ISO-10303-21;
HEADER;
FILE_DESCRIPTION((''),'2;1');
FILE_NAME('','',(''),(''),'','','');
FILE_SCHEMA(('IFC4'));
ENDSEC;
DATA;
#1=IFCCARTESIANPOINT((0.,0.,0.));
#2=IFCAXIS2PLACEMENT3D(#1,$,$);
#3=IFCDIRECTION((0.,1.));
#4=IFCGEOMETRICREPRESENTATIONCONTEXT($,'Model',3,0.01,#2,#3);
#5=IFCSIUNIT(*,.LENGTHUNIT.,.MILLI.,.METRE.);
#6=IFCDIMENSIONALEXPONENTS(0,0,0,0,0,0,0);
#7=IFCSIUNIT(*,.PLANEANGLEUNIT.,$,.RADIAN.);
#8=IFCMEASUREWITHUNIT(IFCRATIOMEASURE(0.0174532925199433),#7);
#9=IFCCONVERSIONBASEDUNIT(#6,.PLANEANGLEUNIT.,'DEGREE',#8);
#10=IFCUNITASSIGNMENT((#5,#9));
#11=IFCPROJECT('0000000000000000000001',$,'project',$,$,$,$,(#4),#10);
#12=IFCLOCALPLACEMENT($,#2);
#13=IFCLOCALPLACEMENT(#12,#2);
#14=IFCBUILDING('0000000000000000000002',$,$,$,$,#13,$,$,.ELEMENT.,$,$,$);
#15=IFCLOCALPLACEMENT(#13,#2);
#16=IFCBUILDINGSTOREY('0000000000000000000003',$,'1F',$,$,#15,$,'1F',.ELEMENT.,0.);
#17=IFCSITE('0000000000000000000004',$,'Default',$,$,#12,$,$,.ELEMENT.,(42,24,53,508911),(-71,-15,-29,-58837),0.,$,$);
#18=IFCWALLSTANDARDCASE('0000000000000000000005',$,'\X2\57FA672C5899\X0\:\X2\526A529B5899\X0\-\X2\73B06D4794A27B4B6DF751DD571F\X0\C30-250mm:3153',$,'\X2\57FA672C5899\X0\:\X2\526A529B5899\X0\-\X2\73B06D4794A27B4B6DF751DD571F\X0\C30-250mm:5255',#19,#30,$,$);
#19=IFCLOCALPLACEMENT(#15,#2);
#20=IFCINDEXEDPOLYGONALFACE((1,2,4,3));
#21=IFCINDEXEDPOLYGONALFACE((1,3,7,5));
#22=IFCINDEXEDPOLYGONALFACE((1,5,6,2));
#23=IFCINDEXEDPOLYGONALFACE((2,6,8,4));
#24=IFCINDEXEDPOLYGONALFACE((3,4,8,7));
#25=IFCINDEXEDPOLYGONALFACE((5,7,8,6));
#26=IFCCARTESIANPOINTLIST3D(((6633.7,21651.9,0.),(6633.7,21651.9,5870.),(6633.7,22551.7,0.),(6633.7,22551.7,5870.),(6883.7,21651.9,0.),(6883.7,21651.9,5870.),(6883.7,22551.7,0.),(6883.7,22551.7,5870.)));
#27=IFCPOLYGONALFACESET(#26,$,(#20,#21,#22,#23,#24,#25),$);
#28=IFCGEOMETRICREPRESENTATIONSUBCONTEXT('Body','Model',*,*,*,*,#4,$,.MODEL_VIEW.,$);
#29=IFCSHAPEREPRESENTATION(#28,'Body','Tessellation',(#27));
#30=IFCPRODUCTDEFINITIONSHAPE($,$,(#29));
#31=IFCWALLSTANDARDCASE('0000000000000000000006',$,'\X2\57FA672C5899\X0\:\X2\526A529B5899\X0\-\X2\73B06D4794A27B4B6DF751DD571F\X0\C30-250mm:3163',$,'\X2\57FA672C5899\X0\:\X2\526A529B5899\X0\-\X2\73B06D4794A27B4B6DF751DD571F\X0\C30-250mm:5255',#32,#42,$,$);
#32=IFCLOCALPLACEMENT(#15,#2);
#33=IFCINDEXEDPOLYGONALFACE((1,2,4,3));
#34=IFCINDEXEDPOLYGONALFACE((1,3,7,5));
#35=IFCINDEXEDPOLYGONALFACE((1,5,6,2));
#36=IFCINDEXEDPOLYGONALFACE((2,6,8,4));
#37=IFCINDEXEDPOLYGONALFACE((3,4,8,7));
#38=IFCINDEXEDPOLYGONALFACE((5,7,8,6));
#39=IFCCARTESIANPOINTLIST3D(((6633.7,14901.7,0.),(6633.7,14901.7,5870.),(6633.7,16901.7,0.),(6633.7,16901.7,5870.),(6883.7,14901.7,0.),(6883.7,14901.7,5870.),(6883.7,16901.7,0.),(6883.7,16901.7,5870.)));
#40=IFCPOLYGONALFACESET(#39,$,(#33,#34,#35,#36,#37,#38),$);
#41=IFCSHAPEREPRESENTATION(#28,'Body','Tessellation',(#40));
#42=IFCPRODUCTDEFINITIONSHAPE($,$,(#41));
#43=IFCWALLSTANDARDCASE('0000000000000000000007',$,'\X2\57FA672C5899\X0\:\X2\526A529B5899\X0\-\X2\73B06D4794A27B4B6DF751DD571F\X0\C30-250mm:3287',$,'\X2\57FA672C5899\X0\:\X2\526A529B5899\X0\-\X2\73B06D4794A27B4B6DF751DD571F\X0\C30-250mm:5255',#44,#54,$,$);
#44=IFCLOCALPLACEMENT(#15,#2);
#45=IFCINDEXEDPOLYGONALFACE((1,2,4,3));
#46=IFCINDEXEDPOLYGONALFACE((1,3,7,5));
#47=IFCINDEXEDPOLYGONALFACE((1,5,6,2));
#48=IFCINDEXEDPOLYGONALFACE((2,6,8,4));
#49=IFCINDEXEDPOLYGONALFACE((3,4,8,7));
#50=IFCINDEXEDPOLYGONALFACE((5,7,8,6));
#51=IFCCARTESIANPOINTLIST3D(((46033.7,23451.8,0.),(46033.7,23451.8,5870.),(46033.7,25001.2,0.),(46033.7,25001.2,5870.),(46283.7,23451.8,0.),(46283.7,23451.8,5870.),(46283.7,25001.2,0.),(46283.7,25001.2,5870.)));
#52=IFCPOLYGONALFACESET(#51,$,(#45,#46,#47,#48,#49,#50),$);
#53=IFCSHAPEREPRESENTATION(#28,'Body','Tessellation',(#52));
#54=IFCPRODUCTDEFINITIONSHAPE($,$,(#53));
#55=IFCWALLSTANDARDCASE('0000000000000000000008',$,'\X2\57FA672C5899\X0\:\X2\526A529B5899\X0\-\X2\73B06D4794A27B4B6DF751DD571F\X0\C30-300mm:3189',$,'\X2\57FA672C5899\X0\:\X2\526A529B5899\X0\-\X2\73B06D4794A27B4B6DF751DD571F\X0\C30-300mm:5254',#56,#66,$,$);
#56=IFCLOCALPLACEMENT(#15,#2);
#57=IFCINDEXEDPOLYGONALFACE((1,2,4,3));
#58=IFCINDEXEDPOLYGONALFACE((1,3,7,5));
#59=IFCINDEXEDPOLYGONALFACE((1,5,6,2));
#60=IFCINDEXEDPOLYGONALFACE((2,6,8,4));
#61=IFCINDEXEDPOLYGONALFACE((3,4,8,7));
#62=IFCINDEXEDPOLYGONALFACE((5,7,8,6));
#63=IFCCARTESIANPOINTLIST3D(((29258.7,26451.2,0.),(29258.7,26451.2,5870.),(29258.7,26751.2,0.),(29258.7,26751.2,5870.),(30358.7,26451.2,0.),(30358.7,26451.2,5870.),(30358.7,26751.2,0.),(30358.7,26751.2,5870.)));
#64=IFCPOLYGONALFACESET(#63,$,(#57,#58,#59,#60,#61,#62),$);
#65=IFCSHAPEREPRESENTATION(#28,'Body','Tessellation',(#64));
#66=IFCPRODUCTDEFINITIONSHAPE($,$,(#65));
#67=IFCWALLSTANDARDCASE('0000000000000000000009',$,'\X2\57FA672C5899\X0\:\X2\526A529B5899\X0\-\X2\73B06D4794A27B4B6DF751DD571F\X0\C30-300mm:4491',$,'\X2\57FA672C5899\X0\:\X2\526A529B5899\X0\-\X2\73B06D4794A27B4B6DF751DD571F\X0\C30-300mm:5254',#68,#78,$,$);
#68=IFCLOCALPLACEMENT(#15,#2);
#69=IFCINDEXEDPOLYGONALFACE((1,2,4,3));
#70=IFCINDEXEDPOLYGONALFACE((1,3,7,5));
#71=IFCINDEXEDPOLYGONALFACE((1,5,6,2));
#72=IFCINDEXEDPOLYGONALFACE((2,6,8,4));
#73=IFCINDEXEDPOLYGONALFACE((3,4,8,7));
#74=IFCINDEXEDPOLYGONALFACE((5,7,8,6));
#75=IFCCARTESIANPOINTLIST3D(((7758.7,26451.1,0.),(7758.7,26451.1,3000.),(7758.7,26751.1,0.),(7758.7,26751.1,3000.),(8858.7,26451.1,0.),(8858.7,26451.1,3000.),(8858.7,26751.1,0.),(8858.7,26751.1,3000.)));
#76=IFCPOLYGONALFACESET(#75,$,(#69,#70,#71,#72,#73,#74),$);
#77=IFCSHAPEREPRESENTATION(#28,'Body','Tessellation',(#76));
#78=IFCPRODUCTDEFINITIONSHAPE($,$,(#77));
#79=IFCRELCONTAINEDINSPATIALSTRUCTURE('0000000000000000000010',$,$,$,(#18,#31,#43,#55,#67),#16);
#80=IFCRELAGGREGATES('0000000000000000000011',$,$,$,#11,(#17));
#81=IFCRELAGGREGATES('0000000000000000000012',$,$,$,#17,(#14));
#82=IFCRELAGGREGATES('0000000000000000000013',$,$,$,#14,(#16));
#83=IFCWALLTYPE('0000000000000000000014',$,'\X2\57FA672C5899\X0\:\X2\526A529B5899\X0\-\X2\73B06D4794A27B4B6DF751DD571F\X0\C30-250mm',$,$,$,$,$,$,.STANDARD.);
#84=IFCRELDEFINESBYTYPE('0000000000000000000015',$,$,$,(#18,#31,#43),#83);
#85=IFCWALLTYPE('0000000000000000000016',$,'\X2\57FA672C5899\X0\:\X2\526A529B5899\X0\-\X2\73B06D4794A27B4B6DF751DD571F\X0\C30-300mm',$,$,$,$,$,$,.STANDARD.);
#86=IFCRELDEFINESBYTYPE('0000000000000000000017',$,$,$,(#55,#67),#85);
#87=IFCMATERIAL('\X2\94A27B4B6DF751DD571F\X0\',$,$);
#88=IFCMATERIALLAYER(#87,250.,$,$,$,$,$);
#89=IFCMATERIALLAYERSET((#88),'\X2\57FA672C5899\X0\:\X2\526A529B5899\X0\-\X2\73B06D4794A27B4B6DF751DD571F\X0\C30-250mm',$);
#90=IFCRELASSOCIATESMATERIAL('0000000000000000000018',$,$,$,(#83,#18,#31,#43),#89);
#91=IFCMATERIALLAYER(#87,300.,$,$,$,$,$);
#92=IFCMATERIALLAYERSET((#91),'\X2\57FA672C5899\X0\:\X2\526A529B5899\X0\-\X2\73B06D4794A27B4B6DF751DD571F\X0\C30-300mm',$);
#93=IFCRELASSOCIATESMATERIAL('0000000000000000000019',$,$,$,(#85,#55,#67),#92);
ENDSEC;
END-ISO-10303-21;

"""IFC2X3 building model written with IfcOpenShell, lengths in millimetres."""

from ifc_helpers import new_model, entity, si_unit, converted_unit, direction, frame, frame_2d, origin, place, context, subcontext, project, spatial, rectangle, extrude, material, layer, layer_set, layer_usage, type_object, element, save


model = new_model("IFC2X3")

# Units and contexts
model_context = context("Model", 3, precision=0.01, world=origin(), true_north=direction((0.0, 1.0)))
body_context = subcontext(model_context, "Body", "Model", "MODEL_VIEW")
ifc_project = project(units=[si_unit("LENGTHUNIT", "METRE", prefix="MILLI"), converted_unit("PLANEANGLEUNIT", "DEGREE", entity("IfcRatioMeasure", 0.0174532925199433), si_unit("PLANEANGLEUNIT", "RADIAN"), dimensions=[0, 0, 0, 0, 0, 0, 0])], contexts=[model_context])

# Site, building, storey
site_placement = place(None, origin())
site = spatial("IfcSite", under=ifc_project, at=site_placement, Name="Default", CompositionType="ELEMENT", RefLatitude=(42, 24, 53, 508911), RefLongitude=(-71, -15, -29, -58837), RefElevation=0.0)
building_placement = place(site_placement, origin())
building = spatial("IfcBuilding", under=site, at=building_placement, CompositionType="ELEMENT")
storey_placement = place(building_placement, origin())
storey = spatial("IfcBuildingStorey", under=building, at=storey_placement, Name="1F", LongName="1F", CompositionType="ELEMENT", Elevation=0.0)

# Walls
ifc_material = material(Name="钢筋混凝土")
ifc_layer_1 = layer(ifc_material, 250.0)
ifc_layer_set_1 = layer_set([ifc_layer_1], Name="基本墙:剪力墙-现浇钢筋混凝土C30-250mm")
ifc_layer_usage_1 = layer_usage(ifc_layer_set_1, "AXIS2", "NEGATIVE", 125.0)
wall_type_1 = type_object("IfcWallType", Name="基本墙:剪力墙-现浇钢筋混凝土C30-250mm", PredefinedType="STANDARD", material=ifc_layer_set_1)
wall_1_placement = place(storey_placement, frame((6758.7, 21651.9, 0.0), z_axis=(0.0, 0.0, 1.0), x_axis=(0.0, 1.0, 0.0)))
element("IfcWallStandardCase", 1, at=wall_1_placement, inside=storey, type_object=wall_type_1, material=ifc_layer_usage_1, Name="基本墙:剪力墙-现浇钢筋混凝土C30-250mm:3153", ObjectType="基本墙:剪力墙-现浇钢筋混凝土C30-250mm:5255", context=body_context, shape_type="SweptSolid", body=[
    extrude(rectangle(XDim=899.8, YDim=250.0, at=frame_2d((449.9, 0.0), x_axis=(-1.0, 0.0))), origin(), (0.0, 0.0, 1.0), 5870.0),
])
ifc_layer_usage_2 = layer_usage(ifc_layer_set_1, "AXIS2", "NEGATIVE", 125.0)
wall_2_placement = place(storey_placement, frame((6758.7, 14901.7, 0.0), z_axis=(0.0, 0.0, 1.0), x_axis=(0.0, 1.0, 0.0)))
element("IfcWallStandardCase", 2, at=wall_2_placement, inside=storey, type_object=wall_type_1, material=ifc_layer_usage_2, Name="基本墙:剪力墙-现浇钢筋混凝土C30-250mm:3163", ObjectType="基本墙:剪力墙-现浇钢筋混凝土C30-250mm:5255", context=body_context, shape_type="SweptSolid", body=[
    extrude(rectangle(XDim=2000.1, YDim=250.0, at=frame_2d((1000.0, 0.0), x_axis=(-1.0, 0.0))), origin(), (0.0, 0.0, 1.0), 5870.0),
])
ifc_layer_usage_3 = layer_usage(ifc_layer_set_1, "AXIS2", "NEGATIVE", 125.0)
wall_3_placement = place(storey_placement, frame((46158.7, 25001.2, 0.0), z_axis=(0.0, 0.0, 1.0), x_axis=(0.0, -1.0, 0.0)))
element("IfcWallStandardCase", 3, at=wall_3_placement, inside=storey, type_object=wall_type_1, material=ifc_layer_usage_3, Name="基本墙:剪力墙-现浇钢筋混凝土C30-250mm:3287", ObjectType="基本墙:剪力墙-现浇钢筋混凝土C30-250mm:5255", context=body_context, shape_type="SweptSolid", body=[
    extrude(rectangle(XDim=1549.4, YDim=250.0, at=frame_2d((774.7, 0.0), x_axis=(-1.0, 0.0))), origin(), (0.0, 0.0, 1.0), 5870.0),
])
ifc_layer_2 = layer(ifc_material, 300.0)
ifc_layer_set_2 = layer_set([ifc_layer_2], Name="基本墙:剪力墙-现浇钢筋混凝土C30-300mm")
ifc_layer_usage_4 = layer_usage(ifc_layer_set_2, "AXIS2", "POSITIVE", -150.0)
wall_type_2 = type_object("IfcWallType", Name="基本墙:剪力墙-现浇钢筋混凝土C30-300mm", PredefinedType="STANDARD", material=ifc_layer_set_2)
wall_4_placement = place(storey_placement, frame((30358.7, 26601.2, 0.0), z_axis=(0.0, 0.0, 1.0), x_axis=(-1.0, 0.0, 0.0)))
element("IfcWallStandardCase", 4, at=wall_4_placement, inside=storey, type_object=wall_type_2, material=ifc_layer_usage_4, Name="基本墙:剪力墙-现浇钢筋混凝土C30-300mm:3189", ObjectType="基本墙:剪力墙-现浇钢筋混凝土C30-300mm:5254", context=body_context, shape_type="SweptSolid", body=[
    extrude(rectangle(XDim=1100.0, YDim=300.0, at=frame_2d((550.0, 0.0), x_axis=(-1.0, 0.0))), origin(), (0.0, 0.0, 1.0), 5870.0),
])
ifc_layer_usage_5 = layer_usage(ifc_layer_set_2, "AXIS2", "NEGATIVE", 150.0)
wall_5_placement = place(storey_placement, frame((7758.7, 26601.1, 0.0)))
element("IfcWallStandardCase", 5, at=wall_5_placement, inside=storey, type_object=wall_type_2, material=ifc_layer_usage_5, Name="基本墙:剪力墙-现浇钢筋混凝土C30-300mm:4491", ObjectType="基本墙:剪力墙-现浇钢筋混凝土C30-300mm:5254", context=body_context, shape_type="SweptSolid", body=[
    extrude(rectangle(XDim=1100.0, YDim=300.0, at=frame_2d((550.0, 0.0), x_axis=(-1.0, 0.0))), origin(), (0.0, 0.0, 1.0), 3000.0),
])

save(model, "model.ifc")
